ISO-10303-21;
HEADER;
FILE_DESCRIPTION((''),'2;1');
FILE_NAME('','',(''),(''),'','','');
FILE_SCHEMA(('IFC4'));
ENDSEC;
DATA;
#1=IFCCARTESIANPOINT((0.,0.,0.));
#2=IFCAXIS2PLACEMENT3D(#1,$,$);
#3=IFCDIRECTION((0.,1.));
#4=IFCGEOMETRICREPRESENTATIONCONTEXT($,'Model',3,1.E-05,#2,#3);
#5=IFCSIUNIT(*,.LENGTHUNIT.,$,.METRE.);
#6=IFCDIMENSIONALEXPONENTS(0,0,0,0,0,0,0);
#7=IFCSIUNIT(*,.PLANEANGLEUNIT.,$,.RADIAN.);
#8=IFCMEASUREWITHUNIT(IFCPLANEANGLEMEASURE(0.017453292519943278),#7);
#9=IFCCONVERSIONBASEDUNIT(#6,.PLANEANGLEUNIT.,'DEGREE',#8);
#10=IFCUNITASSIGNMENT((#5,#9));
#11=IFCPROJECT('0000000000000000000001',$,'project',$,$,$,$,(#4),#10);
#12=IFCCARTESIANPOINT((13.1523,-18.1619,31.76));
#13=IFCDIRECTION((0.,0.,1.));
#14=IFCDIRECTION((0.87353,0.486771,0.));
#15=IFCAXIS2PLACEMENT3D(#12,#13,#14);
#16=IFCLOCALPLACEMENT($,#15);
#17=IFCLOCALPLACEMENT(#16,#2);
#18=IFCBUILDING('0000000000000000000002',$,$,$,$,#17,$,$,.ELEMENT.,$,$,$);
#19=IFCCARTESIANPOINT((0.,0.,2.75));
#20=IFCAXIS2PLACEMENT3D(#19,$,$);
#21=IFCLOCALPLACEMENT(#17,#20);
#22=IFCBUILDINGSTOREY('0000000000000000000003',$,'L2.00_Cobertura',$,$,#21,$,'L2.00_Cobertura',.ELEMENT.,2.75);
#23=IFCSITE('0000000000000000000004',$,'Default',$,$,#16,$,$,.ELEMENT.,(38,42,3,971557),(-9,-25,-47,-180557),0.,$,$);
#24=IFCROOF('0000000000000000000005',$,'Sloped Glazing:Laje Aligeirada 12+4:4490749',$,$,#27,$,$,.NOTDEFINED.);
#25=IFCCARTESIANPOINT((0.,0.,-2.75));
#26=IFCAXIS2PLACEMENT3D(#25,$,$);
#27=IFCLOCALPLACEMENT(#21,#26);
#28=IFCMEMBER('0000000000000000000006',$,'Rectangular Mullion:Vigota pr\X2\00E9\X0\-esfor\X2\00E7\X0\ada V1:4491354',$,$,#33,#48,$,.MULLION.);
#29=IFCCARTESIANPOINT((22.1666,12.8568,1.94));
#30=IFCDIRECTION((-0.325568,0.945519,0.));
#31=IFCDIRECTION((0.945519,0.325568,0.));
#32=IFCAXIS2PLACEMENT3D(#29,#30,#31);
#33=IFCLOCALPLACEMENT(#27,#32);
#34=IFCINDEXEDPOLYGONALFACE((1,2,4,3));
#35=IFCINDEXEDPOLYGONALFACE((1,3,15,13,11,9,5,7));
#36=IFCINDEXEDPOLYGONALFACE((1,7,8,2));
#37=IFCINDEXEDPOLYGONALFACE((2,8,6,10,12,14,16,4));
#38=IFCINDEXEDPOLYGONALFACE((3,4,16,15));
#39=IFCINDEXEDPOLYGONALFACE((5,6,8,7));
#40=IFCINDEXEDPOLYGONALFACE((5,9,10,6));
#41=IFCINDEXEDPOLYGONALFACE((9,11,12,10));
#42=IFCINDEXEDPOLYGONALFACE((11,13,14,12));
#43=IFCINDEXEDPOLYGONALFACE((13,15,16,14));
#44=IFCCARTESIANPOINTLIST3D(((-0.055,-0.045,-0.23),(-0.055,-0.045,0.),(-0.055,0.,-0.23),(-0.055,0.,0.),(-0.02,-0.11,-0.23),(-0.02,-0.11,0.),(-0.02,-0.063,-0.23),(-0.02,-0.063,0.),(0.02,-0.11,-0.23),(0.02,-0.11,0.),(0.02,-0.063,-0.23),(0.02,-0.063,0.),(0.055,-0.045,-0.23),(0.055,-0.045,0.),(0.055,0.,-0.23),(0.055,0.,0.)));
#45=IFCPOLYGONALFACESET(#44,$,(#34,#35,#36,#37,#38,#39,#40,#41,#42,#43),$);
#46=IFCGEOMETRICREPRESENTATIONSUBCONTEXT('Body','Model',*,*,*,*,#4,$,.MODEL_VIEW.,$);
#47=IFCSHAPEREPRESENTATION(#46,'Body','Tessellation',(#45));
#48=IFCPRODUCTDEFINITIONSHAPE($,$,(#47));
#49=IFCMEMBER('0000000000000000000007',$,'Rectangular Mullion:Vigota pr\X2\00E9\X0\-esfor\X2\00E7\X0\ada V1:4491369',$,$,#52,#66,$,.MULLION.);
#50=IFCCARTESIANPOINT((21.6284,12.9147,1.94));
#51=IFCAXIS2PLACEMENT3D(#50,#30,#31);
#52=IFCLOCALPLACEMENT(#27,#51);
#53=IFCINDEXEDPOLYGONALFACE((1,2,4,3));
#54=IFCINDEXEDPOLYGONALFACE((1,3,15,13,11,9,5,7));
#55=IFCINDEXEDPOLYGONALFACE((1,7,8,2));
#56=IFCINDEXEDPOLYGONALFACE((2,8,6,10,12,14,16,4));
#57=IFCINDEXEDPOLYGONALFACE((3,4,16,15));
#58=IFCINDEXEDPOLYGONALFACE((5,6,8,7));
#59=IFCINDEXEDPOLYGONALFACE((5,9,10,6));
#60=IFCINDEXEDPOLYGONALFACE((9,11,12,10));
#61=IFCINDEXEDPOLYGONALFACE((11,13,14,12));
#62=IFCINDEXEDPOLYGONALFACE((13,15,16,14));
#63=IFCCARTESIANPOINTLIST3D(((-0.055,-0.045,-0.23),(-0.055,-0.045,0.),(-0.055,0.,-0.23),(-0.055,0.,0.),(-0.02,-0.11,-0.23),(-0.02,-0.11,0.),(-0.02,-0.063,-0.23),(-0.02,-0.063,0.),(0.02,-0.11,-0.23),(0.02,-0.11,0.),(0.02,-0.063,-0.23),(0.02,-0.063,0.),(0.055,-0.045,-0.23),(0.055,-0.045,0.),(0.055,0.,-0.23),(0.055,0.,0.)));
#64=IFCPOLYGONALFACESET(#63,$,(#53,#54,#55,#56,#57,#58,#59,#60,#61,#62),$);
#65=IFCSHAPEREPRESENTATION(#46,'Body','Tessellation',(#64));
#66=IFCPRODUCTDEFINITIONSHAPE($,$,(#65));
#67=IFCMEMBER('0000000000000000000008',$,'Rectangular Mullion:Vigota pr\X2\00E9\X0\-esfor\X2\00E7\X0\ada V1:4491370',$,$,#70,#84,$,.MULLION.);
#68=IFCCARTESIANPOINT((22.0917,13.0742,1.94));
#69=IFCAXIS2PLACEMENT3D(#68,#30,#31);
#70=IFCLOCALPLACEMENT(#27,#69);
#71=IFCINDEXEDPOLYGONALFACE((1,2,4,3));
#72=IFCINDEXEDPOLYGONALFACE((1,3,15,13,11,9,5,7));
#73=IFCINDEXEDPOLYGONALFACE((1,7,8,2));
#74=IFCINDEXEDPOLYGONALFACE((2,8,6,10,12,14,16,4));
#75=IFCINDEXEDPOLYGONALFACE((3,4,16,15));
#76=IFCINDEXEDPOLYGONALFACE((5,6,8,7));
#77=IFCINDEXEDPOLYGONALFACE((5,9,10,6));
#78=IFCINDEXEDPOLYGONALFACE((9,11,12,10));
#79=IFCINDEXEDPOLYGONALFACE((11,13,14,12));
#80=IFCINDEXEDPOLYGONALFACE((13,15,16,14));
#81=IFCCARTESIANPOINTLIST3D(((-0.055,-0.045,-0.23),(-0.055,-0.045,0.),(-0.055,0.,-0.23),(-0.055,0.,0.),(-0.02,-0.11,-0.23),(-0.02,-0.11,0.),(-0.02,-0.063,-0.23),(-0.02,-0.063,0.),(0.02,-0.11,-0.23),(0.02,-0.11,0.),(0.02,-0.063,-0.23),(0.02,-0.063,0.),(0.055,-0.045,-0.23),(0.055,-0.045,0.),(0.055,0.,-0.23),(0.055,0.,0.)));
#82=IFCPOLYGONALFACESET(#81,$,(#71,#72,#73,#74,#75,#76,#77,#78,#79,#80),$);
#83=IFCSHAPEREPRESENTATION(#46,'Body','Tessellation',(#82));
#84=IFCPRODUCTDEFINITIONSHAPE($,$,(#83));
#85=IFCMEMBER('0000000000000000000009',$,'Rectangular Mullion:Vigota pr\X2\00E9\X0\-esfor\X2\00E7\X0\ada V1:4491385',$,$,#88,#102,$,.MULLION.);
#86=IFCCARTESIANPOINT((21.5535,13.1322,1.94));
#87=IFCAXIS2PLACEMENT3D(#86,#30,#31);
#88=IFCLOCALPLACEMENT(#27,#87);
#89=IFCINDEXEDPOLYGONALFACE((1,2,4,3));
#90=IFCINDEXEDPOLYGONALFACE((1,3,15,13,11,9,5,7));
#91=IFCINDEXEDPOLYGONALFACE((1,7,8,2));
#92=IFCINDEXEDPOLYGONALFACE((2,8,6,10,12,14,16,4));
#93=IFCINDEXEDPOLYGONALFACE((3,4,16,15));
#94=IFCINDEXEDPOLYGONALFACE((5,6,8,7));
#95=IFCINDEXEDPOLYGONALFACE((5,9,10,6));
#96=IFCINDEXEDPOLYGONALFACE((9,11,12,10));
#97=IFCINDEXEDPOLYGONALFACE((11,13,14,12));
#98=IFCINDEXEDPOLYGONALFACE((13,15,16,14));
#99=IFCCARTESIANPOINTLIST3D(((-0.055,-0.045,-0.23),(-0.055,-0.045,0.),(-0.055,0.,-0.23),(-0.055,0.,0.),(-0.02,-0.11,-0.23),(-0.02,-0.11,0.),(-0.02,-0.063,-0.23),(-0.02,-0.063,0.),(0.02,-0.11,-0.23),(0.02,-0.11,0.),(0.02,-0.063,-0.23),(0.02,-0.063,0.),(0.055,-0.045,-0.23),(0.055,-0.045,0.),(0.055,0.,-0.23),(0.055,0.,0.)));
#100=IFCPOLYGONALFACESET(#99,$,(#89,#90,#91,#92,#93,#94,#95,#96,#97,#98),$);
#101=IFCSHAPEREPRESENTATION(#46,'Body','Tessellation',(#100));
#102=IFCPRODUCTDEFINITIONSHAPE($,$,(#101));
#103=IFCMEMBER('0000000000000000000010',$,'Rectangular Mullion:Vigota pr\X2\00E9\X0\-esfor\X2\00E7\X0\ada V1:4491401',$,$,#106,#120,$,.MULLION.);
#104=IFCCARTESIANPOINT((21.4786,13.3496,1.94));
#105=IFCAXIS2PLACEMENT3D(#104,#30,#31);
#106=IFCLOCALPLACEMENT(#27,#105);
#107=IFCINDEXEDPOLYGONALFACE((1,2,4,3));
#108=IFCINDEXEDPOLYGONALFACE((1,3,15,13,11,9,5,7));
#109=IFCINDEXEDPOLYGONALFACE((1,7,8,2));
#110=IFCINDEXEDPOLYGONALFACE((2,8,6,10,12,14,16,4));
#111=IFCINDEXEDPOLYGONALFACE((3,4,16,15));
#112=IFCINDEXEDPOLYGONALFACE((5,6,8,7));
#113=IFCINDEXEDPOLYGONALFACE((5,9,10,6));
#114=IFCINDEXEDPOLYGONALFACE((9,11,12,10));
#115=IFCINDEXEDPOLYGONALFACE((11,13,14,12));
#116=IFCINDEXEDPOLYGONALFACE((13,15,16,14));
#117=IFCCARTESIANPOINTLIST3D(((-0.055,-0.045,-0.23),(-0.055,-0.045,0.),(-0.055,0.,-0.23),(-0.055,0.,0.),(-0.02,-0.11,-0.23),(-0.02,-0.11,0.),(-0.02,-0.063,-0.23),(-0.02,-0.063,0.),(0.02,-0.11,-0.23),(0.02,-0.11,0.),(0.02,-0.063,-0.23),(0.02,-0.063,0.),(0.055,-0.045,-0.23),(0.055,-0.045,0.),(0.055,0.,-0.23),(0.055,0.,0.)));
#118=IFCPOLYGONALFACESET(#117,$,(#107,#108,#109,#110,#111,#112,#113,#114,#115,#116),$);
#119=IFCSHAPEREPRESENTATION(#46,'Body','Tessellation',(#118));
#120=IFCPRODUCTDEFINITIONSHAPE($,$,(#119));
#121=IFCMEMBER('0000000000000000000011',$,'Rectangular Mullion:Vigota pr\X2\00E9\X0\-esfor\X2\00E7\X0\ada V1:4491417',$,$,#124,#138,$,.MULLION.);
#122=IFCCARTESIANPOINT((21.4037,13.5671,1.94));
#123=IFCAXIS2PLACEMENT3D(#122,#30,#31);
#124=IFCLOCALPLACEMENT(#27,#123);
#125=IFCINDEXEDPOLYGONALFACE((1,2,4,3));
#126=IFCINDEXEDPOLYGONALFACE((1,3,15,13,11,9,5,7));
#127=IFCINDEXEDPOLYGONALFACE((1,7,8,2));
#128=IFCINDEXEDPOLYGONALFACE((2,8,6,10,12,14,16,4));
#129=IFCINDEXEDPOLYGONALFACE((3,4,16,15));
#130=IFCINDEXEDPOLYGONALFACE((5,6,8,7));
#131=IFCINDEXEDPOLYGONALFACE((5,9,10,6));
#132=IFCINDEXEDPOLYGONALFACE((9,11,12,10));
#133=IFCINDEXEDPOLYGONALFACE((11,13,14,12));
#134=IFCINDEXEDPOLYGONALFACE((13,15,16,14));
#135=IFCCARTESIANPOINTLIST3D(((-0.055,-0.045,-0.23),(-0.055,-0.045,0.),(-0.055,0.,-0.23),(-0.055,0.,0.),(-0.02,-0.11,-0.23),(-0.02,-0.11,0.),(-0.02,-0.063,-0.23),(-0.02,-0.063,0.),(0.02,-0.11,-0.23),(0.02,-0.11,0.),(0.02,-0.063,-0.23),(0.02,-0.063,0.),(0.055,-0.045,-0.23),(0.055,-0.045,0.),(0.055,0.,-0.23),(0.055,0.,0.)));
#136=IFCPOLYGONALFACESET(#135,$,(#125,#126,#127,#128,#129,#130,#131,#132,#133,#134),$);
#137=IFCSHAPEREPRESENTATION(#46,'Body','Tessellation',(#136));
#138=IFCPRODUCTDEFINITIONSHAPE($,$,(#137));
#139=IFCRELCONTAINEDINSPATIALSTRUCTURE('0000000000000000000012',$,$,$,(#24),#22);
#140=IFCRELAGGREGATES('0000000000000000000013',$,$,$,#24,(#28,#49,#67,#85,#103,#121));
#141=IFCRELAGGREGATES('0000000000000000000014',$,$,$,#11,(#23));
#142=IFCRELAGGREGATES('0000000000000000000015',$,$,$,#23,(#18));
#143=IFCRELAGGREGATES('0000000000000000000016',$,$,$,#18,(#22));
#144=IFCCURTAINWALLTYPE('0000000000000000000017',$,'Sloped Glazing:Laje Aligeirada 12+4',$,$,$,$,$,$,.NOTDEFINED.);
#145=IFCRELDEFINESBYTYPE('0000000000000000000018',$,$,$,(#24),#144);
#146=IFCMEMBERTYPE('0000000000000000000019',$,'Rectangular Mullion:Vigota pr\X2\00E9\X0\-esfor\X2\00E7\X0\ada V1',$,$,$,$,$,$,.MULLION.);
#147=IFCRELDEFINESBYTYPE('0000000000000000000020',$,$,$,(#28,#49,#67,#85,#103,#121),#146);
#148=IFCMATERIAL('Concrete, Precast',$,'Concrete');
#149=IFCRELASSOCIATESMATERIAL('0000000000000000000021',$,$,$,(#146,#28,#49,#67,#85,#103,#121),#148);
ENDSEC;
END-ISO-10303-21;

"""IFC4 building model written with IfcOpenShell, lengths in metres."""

from ifc_helpers import new_model, entity, si_unit, converted_unit, direction, frame, origin, place, context, subcontext, project, spatial, indexed_curve, outline, extrude, source, transform, mapped, material, type_object, type_shapes, element, aggregate, save


model = new_model("IFC4")

# Units and contexts
model_context = context("Model", 3, precision=1e-05, world=origin(), true_north=direction((0.0, 1.0)))
body_context = subcontext(model_context, "Body", "Model", "MODEL_VIEW")
ifc_project = project(units=[si_unit("LENGTHUNIT", "METRE"), converted_unit("PLANEANGLEUNIT", "DEGREE", entity("IfcPlaneAngleMeasure", 0.017453292519943278), si_unit("PLANEANGLEUNIT", "RADIAN"), dimensions=[0, 0, 0, 0, 0, 0, 0])], contexts=[model_context])

# Site, building, storey
site_placement = place(None, frame((13.1523, -18.1619, 31.76), z_axis=(0.0, 0.0, 1.0), x_axis=(0.87353, 0.486771, 0.0)))
site = spatial("IfcSite", under=ifc_project, at=site_placement, Name="Default", CompositionType="ELEMENT", RefLatitude=(38, 42, 3, 971557), RefLongitude=(-9, -25, -47, -180557), RefElevation=0.0)
building_placement = place(site_placement, origin())
building = spatial("IfcBuilding", under=site, at=building_placement, CompositionType="ELEMENT")
storey_placement = place(building_placement, frame((0.0, 0.0, 2.75)))
storey = spatial("IfcBuildingStorey", under=building, at=storey_placement, Name="L2.00_Cobertura", LongName="L2.00_Cobertura", CompositionType="ELEMENT", Elevation=2.75)

# Roof, members
curtain_wall_type = type_object("IfcCurtainWallType", Name="Sloped Glazing:Laje Aligeirada 12+4", PredefinedType="NOTDEFINED")
roof_placement = place(storey_placement, frame((0.0, 0.0, -2.75)))
roof = element("IfcRoof", 1, at=roof_placement, inside=storey, type_object=curtain_wall_type, Name="Sloped Glazing:Laje Aligeirada 12+4:4490749", PredefinedType="NOTDEFINED")
ifc_material_1 = material(Name="Concrete, Precast", Category="Concrete")
member_type = type_object("IfcMemberType", Name="Rectangular Mullion:Vigota pré-esforçada V1", PredefinedType="MULLION", material=ifc_material_1)
shared_shape_1 = source(origin(), body_context, "Body", "SweptSolid", [
    extrude(outline(indexed_curve([(-0.055, -0.0545), (0.055, -0.0545), (0.055, -0.0095), (0.02, 0.0085), (0.02, 0.0555), (-0.02, 0.0555), (-0.02, 0.0085), (-0.055, -0.0095), (-0.055, -0.0545)], self_intersect=False)), frame((0.0, -0.0545, -0.23), z_axis=(0.0, 0.0, 1.0), x_axis=(-1.0, 0.0, 0.0)), (0.0, 0.0, 1.0), 0.23),
])
type_shapes(member_type, [shared_shape_1])
member_1_placement = place(roof_placement, frame((22.1666, 12.8568, 1.94), z_axis=(-0.325568, 0.945519, 0.0), x_axis=(0.945519, 0.325568, 0.0)))
member_1 = element("IfcMember", 2, at=member_1_placement, type_object=member_type, material=ifc_material_1, Name="Rectangular Mullion:Vigota pré-esforçada V1:4491354", PredefinedType="MULLION", context=body_context, shape_type="MappedRepresentation", body=[
    mapped(shared_shape_1, transform((0.0, 0.0, 0.0), scale=1.0)),
])
member_2_placement = place(roof_placement, frame((21.6284, 12.9147, 1.94), z_axis=(-0.325568, 0.945519, 0.0), x_axis=(0.945519, 0.325568, 0.0)))
member_2 = element("IfcMember", 3, at=member_2_placement, type_object=member_type, material=ifc_material_1, Name="Rectangular Mullion:Vigota pré-esforçada V1:4491369", PredefinedType="MULLION", context=body_context, shape_type="MappedRepresentation", body=[
    mapped(shared_shape_1, transform((0.0, 0.0, 0.0), scale=1.0)),
])
member_3_placement = place(roof_placement, frame((22.0917, 13.0742, 1.94), z_axis=(-0.325568, 0.945519, 0.0), x_axis=(0.945519, 0.325568, 0.0)))
member_3 = element("IfcMember", 4, at=member_3_placement, type_object=member_type, material=ifc_material_1, Name="Rectangular Mullion:Vigota pré-esforçada V1:4491370", PredefinedType="MULLION", context=body_context, shape_type="MappedRepresentation", body=[
    mapped(shared_shape_1, transform((0.0, 0.0, 0.0), scale=1.0)),
])
member_4_placement = place(roof_placement, frame((21.5535, 13.1322, 1.94), z_axis=(-0.325568, 0.945519, 0.0), x_axis=(0.945519, 0.325568, 0.0)))
member_4 = element("IfcMember", 5, at=member_4_placement, type_object=member_type, material=ifc_material_1, Name="Rectangular Mullion:Vigota pré-esforçada V1:4491385", PredefinedType="MULLION", context=body_context, shape_type="MappedRepresentation", body=[
    mapped(shared_shape_1, transform((0.0, 0.0, 0.0), scale=1.0)),
])
member_5_placement = place(roof_placement, frame((21.4786, 13.3496, 1.94), z_axis=(-0.325568, 0.945519, 0.0), x_axis=(0.945519, 0.325568, 0.0)))
member_5 = element("IfcMember", 6, at=member_5_placement, type_object=member_type, material=ifc_material_1, Name="Rectangular Mullion:Vigota pré-esforçada V1:4491401", PredefinedType="MULLION", context=body_context, shape_type="MappedRepresentation", body=[
    mapped(shared_shape_1, transform((0.0, 0.0, 0.0), scale=1.0)),
])
member_6_placement = place(roof_placement, frame((21.4037, 13.5671, 1.94), z_axis=(-0.325568, 0.945519, 0.0), x_axis=(0.945519, 0.325568, 0.0)))
member_6 = element("IfcMember", 7, at=member_6_placement, type_object=member_type, material=ifc_material_1, Name="Rectangular Mullion:Vigota pré-esforçada V1:4491417", PredefinedType="MULLION", context=body_context, shape_type="MappedRepresentation", body=[
    mapped(shared_shape_1, transform((0.0, 0.0, 0.0), scale=1.0)),
])
aggregate(roof, [member_1, member_2, member_3, member_4, member_5, member_6])

save(model, "model.ifc")
